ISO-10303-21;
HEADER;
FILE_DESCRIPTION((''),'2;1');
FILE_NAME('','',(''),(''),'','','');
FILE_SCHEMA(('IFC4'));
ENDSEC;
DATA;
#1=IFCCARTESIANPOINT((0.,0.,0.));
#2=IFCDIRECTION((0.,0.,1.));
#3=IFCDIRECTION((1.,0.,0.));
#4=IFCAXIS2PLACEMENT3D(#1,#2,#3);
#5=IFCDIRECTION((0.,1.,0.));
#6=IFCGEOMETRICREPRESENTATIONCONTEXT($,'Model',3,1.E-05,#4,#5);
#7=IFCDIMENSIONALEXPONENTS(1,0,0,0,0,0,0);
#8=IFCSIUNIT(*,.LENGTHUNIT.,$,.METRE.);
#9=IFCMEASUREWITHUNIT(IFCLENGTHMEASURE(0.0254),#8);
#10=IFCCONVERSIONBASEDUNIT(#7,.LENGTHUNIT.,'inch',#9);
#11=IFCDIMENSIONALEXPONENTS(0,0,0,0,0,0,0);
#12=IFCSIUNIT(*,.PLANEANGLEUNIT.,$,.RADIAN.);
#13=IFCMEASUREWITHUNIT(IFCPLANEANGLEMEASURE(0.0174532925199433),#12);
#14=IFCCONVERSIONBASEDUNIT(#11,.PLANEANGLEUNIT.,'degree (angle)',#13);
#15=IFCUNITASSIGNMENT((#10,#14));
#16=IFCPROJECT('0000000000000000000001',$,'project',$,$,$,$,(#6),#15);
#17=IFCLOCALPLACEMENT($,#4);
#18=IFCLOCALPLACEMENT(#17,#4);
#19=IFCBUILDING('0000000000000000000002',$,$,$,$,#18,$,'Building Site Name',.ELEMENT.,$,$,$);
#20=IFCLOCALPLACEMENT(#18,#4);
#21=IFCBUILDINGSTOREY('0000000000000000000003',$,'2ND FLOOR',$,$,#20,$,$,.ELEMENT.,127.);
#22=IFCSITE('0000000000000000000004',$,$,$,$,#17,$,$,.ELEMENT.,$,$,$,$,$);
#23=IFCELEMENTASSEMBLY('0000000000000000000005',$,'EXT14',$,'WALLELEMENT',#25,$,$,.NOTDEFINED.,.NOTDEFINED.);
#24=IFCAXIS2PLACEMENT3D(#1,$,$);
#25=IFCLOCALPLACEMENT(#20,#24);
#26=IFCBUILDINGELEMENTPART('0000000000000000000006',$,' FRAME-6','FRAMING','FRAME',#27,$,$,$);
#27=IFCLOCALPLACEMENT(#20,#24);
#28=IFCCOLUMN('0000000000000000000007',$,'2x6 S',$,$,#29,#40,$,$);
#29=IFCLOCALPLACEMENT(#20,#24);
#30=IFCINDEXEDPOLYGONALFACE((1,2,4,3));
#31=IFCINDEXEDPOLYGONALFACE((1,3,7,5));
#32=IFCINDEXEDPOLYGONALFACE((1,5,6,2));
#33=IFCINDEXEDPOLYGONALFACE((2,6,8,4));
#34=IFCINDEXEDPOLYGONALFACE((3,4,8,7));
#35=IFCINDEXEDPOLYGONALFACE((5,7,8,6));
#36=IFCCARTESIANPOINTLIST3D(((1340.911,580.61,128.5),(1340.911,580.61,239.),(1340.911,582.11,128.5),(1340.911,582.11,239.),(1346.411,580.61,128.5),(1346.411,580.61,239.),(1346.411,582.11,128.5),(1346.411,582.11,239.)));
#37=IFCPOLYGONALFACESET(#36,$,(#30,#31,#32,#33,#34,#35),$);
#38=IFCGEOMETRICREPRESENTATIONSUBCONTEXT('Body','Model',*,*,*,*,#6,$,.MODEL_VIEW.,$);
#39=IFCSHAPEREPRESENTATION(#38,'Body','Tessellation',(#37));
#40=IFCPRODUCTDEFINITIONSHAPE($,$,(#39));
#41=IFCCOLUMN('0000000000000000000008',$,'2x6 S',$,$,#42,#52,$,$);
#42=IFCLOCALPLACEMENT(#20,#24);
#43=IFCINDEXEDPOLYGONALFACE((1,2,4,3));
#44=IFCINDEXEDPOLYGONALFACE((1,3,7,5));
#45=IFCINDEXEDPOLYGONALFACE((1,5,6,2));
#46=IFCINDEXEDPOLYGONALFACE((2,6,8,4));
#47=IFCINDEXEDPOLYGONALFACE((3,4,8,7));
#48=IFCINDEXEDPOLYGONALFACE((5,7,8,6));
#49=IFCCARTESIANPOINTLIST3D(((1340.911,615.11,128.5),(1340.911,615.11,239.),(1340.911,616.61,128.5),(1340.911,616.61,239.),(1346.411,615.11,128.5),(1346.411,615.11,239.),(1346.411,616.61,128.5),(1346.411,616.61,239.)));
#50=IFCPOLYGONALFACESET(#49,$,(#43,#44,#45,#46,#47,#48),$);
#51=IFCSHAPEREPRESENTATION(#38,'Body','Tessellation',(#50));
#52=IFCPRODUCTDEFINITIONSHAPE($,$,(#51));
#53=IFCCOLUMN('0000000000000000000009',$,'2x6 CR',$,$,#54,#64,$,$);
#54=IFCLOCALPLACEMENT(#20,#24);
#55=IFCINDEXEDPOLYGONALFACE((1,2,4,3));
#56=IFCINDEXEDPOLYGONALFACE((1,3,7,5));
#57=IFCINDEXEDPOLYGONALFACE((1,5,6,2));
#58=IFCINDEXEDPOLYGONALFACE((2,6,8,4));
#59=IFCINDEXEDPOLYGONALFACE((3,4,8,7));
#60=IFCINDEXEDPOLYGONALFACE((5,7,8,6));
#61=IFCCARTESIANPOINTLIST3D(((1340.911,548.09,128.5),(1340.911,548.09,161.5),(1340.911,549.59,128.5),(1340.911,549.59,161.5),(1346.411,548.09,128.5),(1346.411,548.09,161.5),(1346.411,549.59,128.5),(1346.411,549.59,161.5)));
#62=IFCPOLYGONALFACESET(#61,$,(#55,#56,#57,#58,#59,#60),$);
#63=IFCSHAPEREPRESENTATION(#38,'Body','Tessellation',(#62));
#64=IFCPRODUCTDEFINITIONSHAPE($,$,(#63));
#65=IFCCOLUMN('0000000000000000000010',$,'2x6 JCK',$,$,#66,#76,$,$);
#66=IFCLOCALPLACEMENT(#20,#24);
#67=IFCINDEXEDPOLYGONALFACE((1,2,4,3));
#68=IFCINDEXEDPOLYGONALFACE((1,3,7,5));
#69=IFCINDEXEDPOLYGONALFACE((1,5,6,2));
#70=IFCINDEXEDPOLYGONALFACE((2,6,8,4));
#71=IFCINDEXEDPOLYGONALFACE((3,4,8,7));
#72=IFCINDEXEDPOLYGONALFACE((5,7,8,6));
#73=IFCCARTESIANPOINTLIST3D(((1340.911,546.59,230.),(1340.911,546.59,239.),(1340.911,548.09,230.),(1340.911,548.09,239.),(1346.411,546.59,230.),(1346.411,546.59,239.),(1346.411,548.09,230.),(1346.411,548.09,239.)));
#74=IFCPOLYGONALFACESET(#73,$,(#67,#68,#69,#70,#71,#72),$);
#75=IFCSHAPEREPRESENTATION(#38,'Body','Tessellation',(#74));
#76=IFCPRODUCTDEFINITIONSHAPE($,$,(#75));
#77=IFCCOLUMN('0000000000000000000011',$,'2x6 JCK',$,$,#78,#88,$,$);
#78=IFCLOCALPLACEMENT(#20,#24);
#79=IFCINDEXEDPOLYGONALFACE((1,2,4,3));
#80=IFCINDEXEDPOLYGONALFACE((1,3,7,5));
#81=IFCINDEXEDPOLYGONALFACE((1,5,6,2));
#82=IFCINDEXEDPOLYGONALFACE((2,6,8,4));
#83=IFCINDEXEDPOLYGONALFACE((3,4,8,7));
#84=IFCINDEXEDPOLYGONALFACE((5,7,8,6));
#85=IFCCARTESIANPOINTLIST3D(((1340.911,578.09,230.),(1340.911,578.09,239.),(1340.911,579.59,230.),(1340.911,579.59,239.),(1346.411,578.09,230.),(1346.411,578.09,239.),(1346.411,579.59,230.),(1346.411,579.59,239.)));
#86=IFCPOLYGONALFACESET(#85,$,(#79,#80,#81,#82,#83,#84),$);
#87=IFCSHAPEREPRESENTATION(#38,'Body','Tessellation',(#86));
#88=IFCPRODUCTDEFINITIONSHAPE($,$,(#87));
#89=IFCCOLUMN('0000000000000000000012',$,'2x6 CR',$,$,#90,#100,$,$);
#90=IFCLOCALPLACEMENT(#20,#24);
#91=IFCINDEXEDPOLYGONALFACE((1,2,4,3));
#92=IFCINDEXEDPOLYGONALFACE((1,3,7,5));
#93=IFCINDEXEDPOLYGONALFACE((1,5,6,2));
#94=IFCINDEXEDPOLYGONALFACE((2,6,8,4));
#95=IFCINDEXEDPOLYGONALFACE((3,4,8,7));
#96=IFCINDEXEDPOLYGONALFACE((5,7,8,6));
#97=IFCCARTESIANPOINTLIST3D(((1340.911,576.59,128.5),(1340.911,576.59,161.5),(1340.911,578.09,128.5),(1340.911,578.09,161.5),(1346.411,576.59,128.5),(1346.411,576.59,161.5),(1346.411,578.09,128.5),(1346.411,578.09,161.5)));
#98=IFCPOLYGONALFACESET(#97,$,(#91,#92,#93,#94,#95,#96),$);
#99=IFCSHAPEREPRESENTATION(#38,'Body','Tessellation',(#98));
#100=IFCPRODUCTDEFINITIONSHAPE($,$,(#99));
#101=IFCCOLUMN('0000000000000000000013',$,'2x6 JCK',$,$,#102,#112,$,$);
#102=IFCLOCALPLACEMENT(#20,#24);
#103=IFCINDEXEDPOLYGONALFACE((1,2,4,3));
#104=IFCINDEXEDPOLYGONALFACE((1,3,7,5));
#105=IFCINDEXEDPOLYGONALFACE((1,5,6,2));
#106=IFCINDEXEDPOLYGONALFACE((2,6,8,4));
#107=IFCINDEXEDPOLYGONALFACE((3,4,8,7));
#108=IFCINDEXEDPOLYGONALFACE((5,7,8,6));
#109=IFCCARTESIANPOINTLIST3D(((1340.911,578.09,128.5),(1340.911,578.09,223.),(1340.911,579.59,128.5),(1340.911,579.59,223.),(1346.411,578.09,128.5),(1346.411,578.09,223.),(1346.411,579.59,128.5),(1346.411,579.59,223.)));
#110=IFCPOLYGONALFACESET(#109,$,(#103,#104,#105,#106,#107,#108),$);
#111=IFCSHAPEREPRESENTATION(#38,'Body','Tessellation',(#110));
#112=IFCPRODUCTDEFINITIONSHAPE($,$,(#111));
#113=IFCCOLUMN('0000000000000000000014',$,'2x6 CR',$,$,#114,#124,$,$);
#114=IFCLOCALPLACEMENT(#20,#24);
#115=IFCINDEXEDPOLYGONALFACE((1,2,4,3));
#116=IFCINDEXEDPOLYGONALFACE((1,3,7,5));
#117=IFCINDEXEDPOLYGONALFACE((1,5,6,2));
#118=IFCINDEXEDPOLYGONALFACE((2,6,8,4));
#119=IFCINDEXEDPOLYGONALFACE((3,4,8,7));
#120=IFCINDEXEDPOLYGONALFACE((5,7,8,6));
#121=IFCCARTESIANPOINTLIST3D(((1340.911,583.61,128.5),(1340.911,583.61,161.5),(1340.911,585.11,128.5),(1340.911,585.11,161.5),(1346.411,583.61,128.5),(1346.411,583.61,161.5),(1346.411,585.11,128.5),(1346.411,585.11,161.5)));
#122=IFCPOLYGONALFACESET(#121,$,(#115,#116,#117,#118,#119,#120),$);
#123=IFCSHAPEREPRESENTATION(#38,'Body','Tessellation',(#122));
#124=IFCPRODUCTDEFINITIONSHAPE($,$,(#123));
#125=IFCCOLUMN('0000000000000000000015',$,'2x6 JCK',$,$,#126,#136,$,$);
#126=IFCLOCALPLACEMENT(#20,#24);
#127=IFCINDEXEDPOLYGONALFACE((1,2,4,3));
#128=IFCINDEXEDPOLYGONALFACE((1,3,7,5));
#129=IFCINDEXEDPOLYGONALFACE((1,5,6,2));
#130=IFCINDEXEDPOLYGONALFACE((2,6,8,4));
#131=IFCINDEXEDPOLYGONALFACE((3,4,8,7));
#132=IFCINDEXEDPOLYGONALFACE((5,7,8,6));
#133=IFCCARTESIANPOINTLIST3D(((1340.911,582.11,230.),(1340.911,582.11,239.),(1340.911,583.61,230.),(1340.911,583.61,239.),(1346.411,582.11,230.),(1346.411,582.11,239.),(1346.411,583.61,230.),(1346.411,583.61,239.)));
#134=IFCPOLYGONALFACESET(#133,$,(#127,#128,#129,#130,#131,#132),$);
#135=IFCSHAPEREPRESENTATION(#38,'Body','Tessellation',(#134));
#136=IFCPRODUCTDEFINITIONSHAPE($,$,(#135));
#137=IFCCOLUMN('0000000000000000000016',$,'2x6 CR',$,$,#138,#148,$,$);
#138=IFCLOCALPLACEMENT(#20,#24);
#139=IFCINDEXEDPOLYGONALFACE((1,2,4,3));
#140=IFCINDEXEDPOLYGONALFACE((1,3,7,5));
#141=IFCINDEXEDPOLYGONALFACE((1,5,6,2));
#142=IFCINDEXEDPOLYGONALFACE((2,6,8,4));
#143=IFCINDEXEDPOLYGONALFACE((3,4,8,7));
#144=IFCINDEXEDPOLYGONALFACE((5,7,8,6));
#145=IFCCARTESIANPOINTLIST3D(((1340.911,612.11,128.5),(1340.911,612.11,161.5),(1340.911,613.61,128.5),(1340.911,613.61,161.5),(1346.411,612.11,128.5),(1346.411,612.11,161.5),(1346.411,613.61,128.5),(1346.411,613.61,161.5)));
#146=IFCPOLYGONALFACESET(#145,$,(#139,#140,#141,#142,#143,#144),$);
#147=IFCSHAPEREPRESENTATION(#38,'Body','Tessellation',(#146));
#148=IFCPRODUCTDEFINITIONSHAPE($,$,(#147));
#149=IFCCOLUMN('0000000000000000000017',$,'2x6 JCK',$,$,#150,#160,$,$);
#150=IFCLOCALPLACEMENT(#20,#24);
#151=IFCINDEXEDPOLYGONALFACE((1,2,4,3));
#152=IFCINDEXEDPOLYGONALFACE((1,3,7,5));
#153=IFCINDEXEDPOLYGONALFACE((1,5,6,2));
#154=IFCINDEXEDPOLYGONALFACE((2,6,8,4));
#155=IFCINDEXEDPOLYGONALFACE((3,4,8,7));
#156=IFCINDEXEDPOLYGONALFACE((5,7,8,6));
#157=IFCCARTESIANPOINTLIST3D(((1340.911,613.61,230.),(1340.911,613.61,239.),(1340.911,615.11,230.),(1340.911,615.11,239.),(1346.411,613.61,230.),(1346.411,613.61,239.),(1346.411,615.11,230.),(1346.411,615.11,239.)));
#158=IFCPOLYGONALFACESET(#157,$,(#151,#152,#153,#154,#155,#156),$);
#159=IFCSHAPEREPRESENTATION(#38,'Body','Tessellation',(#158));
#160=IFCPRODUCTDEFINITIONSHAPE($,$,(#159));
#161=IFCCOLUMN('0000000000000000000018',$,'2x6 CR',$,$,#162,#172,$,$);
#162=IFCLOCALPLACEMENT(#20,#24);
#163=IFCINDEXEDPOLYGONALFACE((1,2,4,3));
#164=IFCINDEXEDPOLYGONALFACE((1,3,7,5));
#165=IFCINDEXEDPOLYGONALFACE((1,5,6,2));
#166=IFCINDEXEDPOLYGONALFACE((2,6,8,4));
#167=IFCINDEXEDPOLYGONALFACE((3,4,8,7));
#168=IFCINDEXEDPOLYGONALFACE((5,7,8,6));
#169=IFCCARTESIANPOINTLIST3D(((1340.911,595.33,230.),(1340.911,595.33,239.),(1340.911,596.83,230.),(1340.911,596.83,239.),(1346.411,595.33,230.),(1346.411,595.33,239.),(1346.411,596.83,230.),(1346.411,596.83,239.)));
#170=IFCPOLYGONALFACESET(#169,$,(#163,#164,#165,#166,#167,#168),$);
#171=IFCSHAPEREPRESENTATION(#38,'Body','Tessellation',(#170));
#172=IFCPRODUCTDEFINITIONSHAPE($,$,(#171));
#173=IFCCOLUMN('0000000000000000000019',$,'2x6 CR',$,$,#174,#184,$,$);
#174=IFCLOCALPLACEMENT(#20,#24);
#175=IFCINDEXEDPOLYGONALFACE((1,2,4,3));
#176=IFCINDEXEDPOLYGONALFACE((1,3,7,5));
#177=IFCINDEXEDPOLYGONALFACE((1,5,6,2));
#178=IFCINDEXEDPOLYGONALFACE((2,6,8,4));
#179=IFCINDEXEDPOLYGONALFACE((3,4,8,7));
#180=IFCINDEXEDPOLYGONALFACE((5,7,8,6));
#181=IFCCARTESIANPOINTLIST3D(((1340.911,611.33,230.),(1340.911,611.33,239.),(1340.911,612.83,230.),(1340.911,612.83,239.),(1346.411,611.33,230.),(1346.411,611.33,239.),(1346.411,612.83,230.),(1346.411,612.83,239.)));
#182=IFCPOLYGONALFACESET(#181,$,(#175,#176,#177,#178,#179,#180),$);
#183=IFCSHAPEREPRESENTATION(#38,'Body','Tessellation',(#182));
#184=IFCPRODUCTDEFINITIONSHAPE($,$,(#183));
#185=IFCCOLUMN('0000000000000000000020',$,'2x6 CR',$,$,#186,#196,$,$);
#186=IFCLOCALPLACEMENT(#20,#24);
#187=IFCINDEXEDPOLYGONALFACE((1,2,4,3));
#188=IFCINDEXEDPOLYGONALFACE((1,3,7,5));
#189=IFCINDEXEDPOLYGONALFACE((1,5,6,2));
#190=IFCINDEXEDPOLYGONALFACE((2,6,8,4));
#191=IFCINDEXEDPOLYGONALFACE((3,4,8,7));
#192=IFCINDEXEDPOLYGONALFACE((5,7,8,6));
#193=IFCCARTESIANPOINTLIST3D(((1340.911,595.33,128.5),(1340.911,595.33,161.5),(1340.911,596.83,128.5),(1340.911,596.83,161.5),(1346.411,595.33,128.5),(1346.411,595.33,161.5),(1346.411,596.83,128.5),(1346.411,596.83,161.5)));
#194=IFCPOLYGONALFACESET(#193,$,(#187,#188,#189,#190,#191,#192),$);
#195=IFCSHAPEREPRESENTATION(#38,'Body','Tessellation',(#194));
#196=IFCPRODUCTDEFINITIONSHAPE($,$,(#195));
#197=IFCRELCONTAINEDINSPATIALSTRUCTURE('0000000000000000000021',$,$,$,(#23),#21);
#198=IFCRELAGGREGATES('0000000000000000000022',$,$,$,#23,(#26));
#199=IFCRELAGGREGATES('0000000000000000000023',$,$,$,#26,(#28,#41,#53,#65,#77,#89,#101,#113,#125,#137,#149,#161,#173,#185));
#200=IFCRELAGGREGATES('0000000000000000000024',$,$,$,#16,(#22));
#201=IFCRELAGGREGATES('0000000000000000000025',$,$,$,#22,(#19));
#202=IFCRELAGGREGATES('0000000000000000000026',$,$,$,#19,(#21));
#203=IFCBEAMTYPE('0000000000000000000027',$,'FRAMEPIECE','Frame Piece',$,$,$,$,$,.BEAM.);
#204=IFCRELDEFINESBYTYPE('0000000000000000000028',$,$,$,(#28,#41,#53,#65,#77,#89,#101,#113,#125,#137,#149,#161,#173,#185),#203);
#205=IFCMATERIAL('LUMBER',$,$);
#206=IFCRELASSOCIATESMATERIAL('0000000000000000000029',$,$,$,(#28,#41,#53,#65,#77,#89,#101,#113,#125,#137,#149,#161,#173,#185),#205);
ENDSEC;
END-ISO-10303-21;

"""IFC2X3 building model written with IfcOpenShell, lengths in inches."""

from ifc_helpers import new_model, entity, si_unit, converted_unit, direction, frame, frame_2d, origin_with_axes, place, context, subcontext, project, spatial, rectangle, extrude, material, type_object, element, aggregate, save


model = new_model("IFC2X3")

# Units and contexts
model_context = context("Model", 3, precision=1e-05, world=origin_with_axes(), true_north=direction((0.0, 1.0, 0.0)))
body_context = subcontext(model_context, "Body", "Model", "MODEL_VIEW")
ifc_project = project(units=[converted_unit("LENGTHUNIT", "inch", entity("IfcLengthMeasure", 0.0254), si_unit("LENGTHUNIT", "METRE"), dimensions=[1, 0, 0, 0, 0, 0, 0]), converted_unit("PLANEANGLEUNIT", "degree (angle)", entity("IfcPlaneAngleMeasure", 0.0174532925199433), si_unit("PLANEANGLEUNIT", "RADIAN"), dimensions=[0, 0, 0, 0, 0, 0, 0])], contexts=[model_context])

# Site, building, storey
site_placement = place(None, origin_with_axes())
site = spatial("IfcSite", under=ifc_project, at=site_placement, CompositionType="ELEMENT")
building_placement = place(site_placement, origin_with_axes())
building = spatial("IfcBuilding", under=site, at=building_placement, LongName="Building Site Name", CompositionType="ELEMENT")
storey_placement = place(building_placement, origin_with_axes())
storey = spatial("IfcBuildingStorey", under=building, at=storey_placement, Name="2ND FLOOR", CompositionType="ELEMENT", Elevation=127.0)

# Element assembly, building element part, columns
assembly_1_placement = place(storey_placement, origin_with_axes())
assembly_1 = element("IfcElementAssembly", 1, at=assembly_1_placement, inside=storey, Name="EXT14", ObjectType="WALLELEMENT", AssemblyPlace="NOTDEFINED", PredefinedType="NOTDEFINED")
building_element_part_1 = element("IfcBuildingElementPart", 2, Name=" FRAME-6", Description="FRAMING", ObjectType="FRAME")
aggregate(assembly_1, [building_element_part_1])
ifc_material_1 = material(Name="LUMBER")
beam_type = type_object("IfcBeamType", Name="FRAMEPIECE", Description="Frame Piece", PredefinedType="BEAM")
column_1_placement = place(assembly_1_placement, frame((1343.661, 581.36, 239.0), z_axis=(0.0, 0.0, -1.0), x_axis=(0.0, 1.0, 0.0)))
column_1 = element("IfcColumn", 3, at=column_1_placement, type_object=beam_type, material=ifc_material_1, Name="2x6 S", context=body_context, shape_type="SweptSolid", body=[
    extrude(rectangle(XDim=1.5, YDim=5.5, at=frame_2d((0.0, 0.0), x_axis=(-1.0, 0.0))), origin_with_axes(), (0.0, 0.0, 1.0), 110.5),
])
column_2_placement = place(assembly_1_placement, frame((1343.661, 615.86, 128.5), z_axis=(0.0, 0.0, 1.0), x_axis=(0.0, -1.0, 0.0)))
column_2 = element("IfcColumn", 4, at=column_2_placement, type_object=beam_type, material=ifc_material_1, Name="2x6 S", context=body_context, shape_type="SweptSolid", body=[
    extrude(rectangle(XDim=1.5, YDim=5.5, at=frame_2d((0.0, 0.0), x_axis=(-1.0, 0.0))), origin_with_axes(), (0.0, 0.0, 1.0), 110.5),
])
column_3_placement = place(assembly_1_placement, frame((1343.661, 548.84, 161.5), z_axis=(0.0, 0.0, -1.0), x_axis=(0.0, 1.0, 0.0)))
column_3 = element("IfcColumn", 5, at=column_3_placement, type_object=beam_type, material=ifc_material_1, Name="2x6 CR", context=body_context, shape_type="SweptSolid", body=[
    extrude(rectangle(XDim=1.5, YDim=5.5, at=frame_2d((0.0, 0.0), x_axis=(-1.0, 0.0))), origin_with_axes(), (0.0, 0.0, 1.0), 33.0),
])
column_4_placement = place(assembly_1_placement, frame((1343.661, 547.34, 239.0), z_axis=(0.0, 0.0, -1.0), x_axis=(0.0, 1.0, 0.0)))
column_4 = element("IfcColumn", 6, at=column_4_placement, type_object=beam_type, material=ifc_material_1, Name="2x6 JCK", context=body_context, shape_type="SweptSolid", body=[
    extrude(rectangle(XDim=1.5, YDim=5.5, at=frame_2d((0.0, 0.0), x_axis=(-1.0, 0.0))), origin_with_axes(), (0.0, 0.0, 1.0), 9.0),
])
column_5_placement = place(assembly_1_placement, frame((1343.661, 578.84, 230.0), z_axis=(0.0, 0.0, 1.0), x_axis=(0.0, -1.0, 0.0)))
column_5 = element("IfcColumn", 7, at=column_5_placement, type_object=beam_type, material=ifc_material_1, Name="2x6 JCK", context=body_context, shape_type="SweptSolid", body=[
    extrude(rectangle(XDim=1.5, YDim=5.5, at=frame_2d((0.0, 0.0), x_axis=(-1.0, 0.0))), origin_with_axes(), (0.0, 0.0, 1.0), 9.0),
])
column_6_placement = place(assembly_1_placement, frame((1343.661, 577.34, 128.5), z_axis=(0.0, 0.0, 1.0), x_axis=(0.0, -1.0, 0.0)))
column_6 = element("IfcColumn", 8, at=column_6_placement, type_object=beam_type, material=ifc_material_1, Name="2x6 CR", context=body_context, shape_type="SweptSolid", body=[
    extrude(rectangle(XDim=1.5, YDim=5.5, at=frame_2d((0.0, 0.0), x_axis=(-1.0, 0.0))), origin_with_axes(), (0.0, 0.0, 1.0), 33.0),
])
column_7_placement = place(assembly_1_placement, frame((1343.661, 578.84, 128.5), z_axis=(0.0, 0.0, 1.0), x_axis=(0.0, -1.0, 0.0)))
column_7 = element("IfcColumn", 9, at=column_7_placement, type_object=beam_type, material=ifc_material_1, Name="2x6 JCK", context=body_context, shape_type="SweptSolid", body=[
    extrude(rectangle(XDim=1.5, YDim=5.5, at=frame_2d((0.0, 0.0), x_axis=(-1.0, 0.0))), origin_with_axes(), (0.0, 0.0, 1.0), 94.5),
])
column_8_placement = place(assembly_1_placement, frame((1343.661, 584.36, 161.5), z_axis=(0.0, 0.0, -1.0), x_axis=(0.0, 1.0, 0.0)))
column_8 = element("IfcColumn", 10, at=column_8_placement, type_object=beam_type, material=ifc_material_1, Name="2x6 CR", context=body_context, shape_type="SweptSolid", body=[
    extrude(rectangle(XDim=1.5, YDim=5.5, at=frame_2d((0.0, 0.0), x_axis=(-1.0, 0.0))), origin_with_axes(), (0.0, 0.0, 1.0), 33.0),
])
column_9_placement = place(assembly_1_placement, frame((1343.661, 582.86, 239.0), z_axis=(0.0, 0.0, -1.0), x_axis=(0.0, 1.0, 0.0)))
column_9 = element("IfcColumn", 11, at=column_9_placement, type_object=beam_type, material=ifc_material_1, Name="2x6 JCK", context=body_context, shape_type="SweptSolid", body=[
    extrude(rectangle(XDim=1.5, YDim=5.5, at=frame_2d((0.0, 0.0), x_axis=(-1.0, 0.0))), origin_with_axes(), (0.0, 0.0, 1.0), 9.0),
])
column_10_placement = place(assembly_1_placement, frame((1343.661, 612.86, 128.5), z_axis=(0.0, 0.0, 1.0), x_axis=(0.0, -1.0, 0.0)))
column_10 = element("IfcColumn", 12, at=column_10_placement, type_object=beam_type, material=ifc_material_1, Name="2x6 CR", context=body_context, shape_type="SweptSolid", body=[
    extrude(rectangle(XDim=1.5, YDim=5.5, at=frame_2d((0.0, 0.0), x_axis=(-1.0, 0.0))), origin_with_axes(), (0.0, 0.0, 1.0), 33.0),
])
column_11_placement = place(assembly_1_placement, frame((1343.661, 614.36, 230.0), z_axis=(0.0, 0.0, 1.0), x_axis=(0.0, -1.0, 0.0)))
column_11 = element("IfcColumn", 13, at=column_11_placement, type_object=beam_type, material=ifc_material_1, Name="2x6 JCK", context=body_context, shape_type="SweptSolid", body=[
    extrude(rectangle(XDim=1.5, YDim=5.5, at=frame_2d((0.0, 0.0), x_axis=(-1.0, 0.0))), origin_with_axes(), (0.0, 0.0, 1.0), 9.0),
])
column_12_placement = place(assembly_1_placement, frame((1343.661, 596.08, 239.0), z_axis=(0.0, 0.0, -1.0), x_axis=(0.0, 1.0, 0.0)))
column_12 = element("IfcColumn", 14, at=column_12_placement, type_object=beam_type, material=ifc_material_1, Name="2x6 CR", context=body_context, shape_type="SweptSolid", body=[
    extrude(rectangle(XDim=1.5, YDim=5.5, at=frame_2d((0.0, 0.0), x_axis=(-1.0, 0.0))), origin_with_axes(), (0.0, 0.0, 1.0), 9.0),
])
column_13_placement = place(assembly_1_placement, frame((1343.661, 612.08, 239.0), z_axis=(0.0, 0.0, -1.0), x_axis=(0.0, 1.0, 0.0)))
column_13 = element("IfcColumn", 15, at=column_13_placement, type_object=beam_type, material=ifc_material_1, Name="2x6 CR", context=body_context, shape_type="SweptSolid", body=[
    extrude(rectangle(XDim=1.5, YDim=5.5, at=frame_2d((0.0, 0.0), x_axis=(-1.0, 0.0))), origin_with_axes(), (0.0, 0.0, 1.0), 9.0),
])
column_14_placement = place(assembly_1_placement, frame((1343.661, 596.08, 161.5), z_axis=(0.0, 0.0, -1.0), x_axis=(0.0, 1.0, 0.0)))
column_14 = element("IfcColumn", 16, at=column_14_placement, type_object=beam_type, material=ifc_material_1, Name="2x6 CR", context=body_context, shape_type="SweptSolid", body=[
    extrude(rectangle(XDim=1.5, YDim=5.5, at=frame_2d((0.0, 0.0), x_axis=(-1.0, 0.0))), origin_with_axes(), (0.0, 0.0, 1.0), 33.0),
])

aggregate(building_element_part_1, [column_1, column_2, column_3, column_4, column_5, column_6, column_7, column_8, column_9, column_10, column_11, column_12, column_13, column_14])

save(model, "model.ifc")
